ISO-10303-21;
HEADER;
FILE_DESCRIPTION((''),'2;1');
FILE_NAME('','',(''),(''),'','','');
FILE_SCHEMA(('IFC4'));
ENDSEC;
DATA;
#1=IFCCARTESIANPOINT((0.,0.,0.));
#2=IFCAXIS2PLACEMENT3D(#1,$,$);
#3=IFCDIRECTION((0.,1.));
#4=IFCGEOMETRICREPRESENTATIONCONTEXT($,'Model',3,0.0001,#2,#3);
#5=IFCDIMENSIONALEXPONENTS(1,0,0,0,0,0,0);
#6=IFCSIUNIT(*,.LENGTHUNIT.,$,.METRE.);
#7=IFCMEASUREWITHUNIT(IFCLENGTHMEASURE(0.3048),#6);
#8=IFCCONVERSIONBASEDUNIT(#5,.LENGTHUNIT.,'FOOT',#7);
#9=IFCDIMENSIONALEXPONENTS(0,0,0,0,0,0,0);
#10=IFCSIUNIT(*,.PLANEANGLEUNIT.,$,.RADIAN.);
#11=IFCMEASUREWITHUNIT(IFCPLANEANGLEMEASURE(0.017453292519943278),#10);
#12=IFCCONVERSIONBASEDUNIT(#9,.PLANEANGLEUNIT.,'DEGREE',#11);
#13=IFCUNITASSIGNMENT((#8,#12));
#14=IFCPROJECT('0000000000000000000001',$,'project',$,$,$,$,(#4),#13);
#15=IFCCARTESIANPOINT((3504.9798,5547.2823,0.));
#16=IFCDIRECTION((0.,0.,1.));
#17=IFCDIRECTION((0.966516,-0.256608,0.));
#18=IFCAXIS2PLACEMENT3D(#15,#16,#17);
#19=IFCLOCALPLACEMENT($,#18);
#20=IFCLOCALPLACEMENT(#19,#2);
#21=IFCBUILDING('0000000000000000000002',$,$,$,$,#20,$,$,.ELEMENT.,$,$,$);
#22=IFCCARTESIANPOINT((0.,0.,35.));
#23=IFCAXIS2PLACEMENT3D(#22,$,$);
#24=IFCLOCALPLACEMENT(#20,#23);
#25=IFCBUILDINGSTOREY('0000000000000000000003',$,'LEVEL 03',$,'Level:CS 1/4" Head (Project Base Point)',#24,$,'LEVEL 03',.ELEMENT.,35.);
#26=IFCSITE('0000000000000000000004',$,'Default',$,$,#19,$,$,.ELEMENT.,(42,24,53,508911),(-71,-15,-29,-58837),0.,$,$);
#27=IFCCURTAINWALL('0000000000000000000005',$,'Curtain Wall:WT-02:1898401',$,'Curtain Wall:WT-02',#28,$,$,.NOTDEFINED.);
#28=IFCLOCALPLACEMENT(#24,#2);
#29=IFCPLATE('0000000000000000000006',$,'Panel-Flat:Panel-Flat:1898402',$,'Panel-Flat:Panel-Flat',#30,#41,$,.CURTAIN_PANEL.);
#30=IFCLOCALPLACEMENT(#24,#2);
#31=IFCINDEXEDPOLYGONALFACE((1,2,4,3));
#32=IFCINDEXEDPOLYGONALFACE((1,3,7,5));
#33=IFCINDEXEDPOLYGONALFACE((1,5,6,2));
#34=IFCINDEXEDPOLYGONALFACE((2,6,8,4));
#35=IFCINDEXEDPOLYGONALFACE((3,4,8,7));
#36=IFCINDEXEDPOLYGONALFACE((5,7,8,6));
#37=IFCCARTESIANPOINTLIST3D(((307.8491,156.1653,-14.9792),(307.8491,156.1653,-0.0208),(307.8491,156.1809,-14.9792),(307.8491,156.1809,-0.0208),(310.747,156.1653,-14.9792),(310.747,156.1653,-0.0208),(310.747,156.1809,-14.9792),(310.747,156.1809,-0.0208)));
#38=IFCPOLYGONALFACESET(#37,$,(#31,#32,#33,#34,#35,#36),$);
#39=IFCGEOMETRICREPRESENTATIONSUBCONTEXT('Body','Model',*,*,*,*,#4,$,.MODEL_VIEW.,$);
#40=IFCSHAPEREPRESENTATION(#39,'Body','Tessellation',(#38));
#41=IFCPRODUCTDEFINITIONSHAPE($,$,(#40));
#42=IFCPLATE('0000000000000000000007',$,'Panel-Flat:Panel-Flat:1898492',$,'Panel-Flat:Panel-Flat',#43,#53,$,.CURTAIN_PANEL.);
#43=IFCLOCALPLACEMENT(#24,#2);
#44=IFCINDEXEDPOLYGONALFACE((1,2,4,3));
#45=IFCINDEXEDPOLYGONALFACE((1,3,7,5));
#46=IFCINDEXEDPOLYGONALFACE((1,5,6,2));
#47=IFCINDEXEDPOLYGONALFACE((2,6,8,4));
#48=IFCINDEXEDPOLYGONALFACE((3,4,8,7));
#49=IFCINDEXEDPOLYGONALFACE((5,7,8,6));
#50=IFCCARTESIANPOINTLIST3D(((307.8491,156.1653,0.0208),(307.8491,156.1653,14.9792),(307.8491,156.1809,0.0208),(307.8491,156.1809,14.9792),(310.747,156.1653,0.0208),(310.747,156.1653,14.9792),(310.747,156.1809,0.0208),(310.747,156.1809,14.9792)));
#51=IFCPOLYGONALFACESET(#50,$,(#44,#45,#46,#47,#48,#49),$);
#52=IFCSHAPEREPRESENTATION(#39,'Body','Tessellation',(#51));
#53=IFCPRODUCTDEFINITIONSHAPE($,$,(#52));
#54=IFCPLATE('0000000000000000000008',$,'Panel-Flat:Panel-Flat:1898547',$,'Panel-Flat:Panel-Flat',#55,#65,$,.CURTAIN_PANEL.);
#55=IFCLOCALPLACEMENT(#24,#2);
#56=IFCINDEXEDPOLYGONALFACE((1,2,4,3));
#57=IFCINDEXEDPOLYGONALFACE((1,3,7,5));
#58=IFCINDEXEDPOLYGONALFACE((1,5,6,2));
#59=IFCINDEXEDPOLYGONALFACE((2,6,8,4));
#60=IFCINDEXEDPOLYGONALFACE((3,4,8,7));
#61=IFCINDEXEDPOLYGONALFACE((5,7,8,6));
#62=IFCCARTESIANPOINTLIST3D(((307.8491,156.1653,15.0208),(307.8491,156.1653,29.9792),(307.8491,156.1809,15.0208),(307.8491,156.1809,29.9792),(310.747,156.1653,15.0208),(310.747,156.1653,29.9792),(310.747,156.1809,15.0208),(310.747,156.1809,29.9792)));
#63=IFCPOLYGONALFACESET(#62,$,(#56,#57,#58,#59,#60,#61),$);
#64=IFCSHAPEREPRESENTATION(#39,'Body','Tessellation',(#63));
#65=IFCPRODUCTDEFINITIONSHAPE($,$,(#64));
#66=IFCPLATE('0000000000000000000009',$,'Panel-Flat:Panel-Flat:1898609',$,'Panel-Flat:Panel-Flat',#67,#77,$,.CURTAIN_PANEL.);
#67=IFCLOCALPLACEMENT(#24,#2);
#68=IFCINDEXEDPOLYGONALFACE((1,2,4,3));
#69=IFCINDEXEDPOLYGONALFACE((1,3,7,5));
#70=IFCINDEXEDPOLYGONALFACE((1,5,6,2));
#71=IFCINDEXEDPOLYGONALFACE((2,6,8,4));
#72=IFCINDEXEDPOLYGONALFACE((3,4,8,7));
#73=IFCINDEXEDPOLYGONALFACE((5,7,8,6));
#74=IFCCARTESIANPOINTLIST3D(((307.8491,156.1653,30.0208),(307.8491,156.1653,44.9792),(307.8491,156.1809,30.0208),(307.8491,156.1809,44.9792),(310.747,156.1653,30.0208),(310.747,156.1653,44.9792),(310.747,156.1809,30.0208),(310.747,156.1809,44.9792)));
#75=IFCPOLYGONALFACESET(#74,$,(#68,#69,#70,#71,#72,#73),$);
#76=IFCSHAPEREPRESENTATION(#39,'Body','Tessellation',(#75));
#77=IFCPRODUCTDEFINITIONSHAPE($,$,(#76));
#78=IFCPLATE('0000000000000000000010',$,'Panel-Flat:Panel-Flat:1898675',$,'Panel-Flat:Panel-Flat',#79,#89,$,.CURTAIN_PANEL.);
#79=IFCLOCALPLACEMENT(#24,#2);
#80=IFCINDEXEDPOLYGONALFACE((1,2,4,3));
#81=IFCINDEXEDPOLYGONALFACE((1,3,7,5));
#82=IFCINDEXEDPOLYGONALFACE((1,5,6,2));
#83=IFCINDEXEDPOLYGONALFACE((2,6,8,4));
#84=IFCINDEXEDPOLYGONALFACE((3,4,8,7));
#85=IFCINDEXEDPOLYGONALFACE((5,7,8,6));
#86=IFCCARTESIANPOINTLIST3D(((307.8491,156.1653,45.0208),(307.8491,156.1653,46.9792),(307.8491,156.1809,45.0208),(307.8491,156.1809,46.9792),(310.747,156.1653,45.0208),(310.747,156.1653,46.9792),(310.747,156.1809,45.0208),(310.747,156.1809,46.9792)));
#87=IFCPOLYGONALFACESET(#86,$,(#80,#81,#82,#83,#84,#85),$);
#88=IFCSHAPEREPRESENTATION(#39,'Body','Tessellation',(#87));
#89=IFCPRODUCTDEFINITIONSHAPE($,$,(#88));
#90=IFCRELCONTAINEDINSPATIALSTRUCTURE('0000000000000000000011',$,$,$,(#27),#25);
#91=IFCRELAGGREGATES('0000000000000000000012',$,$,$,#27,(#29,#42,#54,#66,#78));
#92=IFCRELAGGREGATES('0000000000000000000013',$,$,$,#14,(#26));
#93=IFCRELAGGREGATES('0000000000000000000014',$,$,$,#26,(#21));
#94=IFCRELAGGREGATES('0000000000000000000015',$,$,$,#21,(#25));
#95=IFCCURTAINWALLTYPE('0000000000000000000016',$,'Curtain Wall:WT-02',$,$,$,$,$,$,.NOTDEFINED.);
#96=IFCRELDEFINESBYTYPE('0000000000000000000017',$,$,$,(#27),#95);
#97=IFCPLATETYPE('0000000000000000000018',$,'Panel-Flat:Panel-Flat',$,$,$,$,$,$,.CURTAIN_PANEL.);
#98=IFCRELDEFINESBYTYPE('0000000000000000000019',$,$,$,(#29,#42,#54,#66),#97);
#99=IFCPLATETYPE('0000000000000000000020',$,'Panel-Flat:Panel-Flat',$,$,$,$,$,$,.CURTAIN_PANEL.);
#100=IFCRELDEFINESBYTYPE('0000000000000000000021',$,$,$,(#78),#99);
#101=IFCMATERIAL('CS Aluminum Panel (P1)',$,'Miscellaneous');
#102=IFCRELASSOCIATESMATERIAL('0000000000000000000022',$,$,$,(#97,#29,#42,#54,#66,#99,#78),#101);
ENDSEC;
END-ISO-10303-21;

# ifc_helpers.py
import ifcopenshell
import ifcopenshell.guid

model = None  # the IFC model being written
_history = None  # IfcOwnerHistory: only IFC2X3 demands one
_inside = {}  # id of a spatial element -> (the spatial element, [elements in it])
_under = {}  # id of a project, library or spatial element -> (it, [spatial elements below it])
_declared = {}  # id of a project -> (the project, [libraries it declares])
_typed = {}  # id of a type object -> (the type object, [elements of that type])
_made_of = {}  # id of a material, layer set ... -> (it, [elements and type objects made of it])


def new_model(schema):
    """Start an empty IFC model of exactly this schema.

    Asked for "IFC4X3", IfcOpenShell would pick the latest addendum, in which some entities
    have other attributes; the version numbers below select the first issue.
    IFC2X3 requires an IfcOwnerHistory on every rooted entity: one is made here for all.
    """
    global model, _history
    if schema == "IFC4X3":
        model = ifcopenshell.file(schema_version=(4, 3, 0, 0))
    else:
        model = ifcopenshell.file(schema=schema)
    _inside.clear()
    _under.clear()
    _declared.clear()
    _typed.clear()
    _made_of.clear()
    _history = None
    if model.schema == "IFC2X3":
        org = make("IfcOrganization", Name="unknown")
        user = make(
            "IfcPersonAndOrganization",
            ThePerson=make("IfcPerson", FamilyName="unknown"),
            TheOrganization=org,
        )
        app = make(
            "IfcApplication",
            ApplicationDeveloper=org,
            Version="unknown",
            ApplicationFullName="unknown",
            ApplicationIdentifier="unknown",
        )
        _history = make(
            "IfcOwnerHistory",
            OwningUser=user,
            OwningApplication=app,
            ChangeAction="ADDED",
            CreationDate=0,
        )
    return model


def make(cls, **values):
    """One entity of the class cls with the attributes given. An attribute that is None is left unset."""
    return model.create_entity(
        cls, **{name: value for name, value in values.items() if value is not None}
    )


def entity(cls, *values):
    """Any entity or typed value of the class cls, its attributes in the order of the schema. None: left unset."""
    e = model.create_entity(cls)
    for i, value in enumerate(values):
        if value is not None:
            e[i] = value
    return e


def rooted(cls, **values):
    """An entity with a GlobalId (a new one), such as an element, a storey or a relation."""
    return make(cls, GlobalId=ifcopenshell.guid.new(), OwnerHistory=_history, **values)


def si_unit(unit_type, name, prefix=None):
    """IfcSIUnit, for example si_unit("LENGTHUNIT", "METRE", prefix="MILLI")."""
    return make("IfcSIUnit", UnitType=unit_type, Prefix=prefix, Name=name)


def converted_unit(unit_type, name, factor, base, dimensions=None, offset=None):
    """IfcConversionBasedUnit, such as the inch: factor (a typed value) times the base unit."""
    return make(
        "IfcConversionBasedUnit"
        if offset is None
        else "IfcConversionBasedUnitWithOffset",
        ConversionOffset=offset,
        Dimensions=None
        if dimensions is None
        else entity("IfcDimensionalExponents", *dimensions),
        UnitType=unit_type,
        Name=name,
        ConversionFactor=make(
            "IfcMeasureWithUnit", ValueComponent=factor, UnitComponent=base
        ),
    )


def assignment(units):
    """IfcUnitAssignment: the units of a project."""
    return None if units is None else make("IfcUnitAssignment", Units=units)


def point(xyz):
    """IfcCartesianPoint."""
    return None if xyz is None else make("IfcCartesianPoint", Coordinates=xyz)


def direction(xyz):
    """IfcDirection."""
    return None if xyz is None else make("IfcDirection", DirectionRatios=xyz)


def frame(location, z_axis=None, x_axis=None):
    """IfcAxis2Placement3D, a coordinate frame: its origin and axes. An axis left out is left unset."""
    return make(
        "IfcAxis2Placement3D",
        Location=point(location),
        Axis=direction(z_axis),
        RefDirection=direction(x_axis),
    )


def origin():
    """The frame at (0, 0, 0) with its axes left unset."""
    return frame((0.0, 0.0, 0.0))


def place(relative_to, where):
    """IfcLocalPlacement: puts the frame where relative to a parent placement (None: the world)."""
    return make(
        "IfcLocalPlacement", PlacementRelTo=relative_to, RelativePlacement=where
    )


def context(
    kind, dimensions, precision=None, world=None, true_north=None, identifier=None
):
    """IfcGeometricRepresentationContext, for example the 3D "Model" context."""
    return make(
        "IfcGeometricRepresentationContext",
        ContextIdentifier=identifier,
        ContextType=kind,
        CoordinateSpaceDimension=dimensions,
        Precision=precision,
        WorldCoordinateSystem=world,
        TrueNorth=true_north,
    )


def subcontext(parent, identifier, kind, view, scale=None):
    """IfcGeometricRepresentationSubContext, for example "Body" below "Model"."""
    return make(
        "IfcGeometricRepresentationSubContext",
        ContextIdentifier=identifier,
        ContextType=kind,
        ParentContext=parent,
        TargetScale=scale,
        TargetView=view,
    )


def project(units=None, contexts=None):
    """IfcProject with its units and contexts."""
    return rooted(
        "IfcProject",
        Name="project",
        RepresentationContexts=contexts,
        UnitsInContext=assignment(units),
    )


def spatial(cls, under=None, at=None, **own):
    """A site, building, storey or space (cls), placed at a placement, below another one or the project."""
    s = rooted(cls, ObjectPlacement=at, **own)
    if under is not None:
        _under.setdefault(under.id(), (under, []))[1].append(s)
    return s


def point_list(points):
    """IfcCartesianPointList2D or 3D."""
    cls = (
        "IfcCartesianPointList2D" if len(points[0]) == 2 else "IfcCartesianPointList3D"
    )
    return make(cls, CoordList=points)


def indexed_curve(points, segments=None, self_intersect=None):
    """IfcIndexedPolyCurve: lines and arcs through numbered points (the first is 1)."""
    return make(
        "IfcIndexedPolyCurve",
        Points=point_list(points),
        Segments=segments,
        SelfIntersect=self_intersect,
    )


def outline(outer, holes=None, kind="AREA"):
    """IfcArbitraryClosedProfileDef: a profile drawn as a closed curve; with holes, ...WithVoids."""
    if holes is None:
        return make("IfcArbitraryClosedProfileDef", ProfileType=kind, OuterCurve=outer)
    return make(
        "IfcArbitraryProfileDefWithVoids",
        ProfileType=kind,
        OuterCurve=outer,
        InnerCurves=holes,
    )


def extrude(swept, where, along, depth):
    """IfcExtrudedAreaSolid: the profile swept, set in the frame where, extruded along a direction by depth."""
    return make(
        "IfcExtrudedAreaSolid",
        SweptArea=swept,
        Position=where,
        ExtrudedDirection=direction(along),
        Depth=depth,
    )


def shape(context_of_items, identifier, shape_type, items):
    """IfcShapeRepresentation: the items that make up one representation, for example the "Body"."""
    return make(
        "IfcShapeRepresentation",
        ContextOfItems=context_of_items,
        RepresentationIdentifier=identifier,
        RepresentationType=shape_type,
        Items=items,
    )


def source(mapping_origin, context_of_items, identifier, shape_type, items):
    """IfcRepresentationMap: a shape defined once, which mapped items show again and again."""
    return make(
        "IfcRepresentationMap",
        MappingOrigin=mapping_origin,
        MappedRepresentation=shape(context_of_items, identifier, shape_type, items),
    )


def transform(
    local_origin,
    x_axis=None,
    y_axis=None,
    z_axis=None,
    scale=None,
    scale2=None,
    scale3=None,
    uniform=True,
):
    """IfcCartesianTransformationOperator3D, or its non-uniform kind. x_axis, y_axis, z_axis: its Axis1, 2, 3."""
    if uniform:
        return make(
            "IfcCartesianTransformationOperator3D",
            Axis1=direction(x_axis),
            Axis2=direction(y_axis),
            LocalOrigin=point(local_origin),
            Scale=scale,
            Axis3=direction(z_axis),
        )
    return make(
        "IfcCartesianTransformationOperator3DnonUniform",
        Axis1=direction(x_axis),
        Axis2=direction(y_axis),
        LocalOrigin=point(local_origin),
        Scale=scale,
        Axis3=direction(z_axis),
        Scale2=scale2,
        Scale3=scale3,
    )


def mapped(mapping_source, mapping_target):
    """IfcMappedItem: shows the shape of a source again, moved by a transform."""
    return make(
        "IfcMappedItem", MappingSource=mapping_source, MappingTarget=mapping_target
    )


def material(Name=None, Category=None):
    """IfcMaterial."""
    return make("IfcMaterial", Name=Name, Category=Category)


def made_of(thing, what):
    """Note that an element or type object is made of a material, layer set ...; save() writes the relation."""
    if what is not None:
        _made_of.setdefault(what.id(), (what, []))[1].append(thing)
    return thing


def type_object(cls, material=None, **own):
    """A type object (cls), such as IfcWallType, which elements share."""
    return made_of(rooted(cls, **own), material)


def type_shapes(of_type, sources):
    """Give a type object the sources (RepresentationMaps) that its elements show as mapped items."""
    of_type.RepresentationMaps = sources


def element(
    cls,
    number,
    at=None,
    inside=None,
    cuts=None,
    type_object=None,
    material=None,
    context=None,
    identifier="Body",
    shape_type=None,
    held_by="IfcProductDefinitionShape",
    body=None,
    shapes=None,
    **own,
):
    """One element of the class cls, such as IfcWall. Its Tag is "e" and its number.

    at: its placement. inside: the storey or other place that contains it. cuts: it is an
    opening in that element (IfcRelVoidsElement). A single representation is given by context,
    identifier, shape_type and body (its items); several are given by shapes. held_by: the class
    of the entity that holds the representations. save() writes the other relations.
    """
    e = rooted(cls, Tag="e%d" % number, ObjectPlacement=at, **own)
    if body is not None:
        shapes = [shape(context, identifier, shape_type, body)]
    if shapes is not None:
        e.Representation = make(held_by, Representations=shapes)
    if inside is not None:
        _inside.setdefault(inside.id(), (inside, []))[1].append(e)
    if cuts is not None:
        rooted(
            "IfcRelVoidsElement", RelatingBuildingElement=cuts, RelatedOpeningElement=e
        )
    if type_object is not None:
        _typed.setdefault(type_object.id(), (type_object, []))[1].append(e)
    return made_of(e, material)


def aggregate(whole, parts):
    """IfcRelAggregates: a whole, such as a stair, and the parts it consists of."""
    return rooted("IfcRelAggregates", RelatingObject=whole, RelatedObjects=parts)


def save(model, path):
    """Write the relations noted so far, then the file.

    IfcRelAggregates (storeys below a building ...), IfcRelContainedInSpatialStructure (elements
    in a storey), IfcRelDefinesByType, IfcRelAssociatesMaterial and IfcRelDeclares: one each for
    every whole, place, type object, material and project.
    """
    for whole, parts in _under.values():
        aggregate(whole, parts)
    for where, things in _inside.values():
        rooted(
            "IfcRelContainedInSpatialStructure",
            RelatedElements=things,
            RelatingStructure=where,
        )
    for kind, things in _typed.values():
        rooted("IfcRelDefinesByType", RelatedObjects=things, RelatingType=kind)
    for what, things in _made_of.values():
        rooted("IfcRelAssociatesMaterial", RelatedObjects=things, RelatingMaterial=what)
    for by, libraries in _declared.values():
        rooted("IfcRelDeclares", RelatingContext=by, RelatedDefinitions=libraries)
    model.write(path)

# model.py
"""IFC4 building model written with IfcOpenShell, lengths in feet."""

from ifc_helpers import new_model, entity, si_unit, converted_unit, direction, frame, origin, place, context, subcontext, project, spatial, indexed_curve, outline, extrude, source, transform, mapped, material, type_object, type_shapes, element, aggregate, save


model = new_model("IFC4")

# Units and contexts
model_context = context("Model", 3, precision=0.0001, world=origin(), true_north=direction((0.0, 1.0)))
body_context = subcontext(model_context, "Body", "Model", "MODEL_VIEW")
ifc_project = project(units=[converted_unit("LENGTHUNIT", "FOOT", entity("IfcLengthMeasure", 0.3048), si_unit("LENGTHUNIT", "METRE"), dimensions=[1, 0, 0, 0, 0, 0, 0]), converted_unit("PLANEANGLEUNIT", "DEGREE", entity("IfcPlaneAngleMeasure", 0.017453292519943278), si_unit("PLANEANGLEUNIT", "RADIAN"), dimensions=[0, 0, 0, 0, 0, 0, 0])], contexts=[model_context])

# Site, building, storey
site_placement = place(None, frame((3504.9798, 5547.2823, 0.0), z_axis=(0.0, 0.0, 1.0), x_axis=(0.966516, -0.256608, 0.0)))
site = spatial("IfcSite", under=ifc_project, at=site_placement, Name="Default", CompositionType="ELEMENT", RefLatitude=(42, 24, 53, 508911), RefLongitude=(-71, -15, -29, -58837), RefElevation=0.0)
building_placement = place(site_placement, origin())
building = spatial("IfcBuilding", under=site, at=building_placement, CompositionType="ELEMENT")
storey_placement = place(building_placement, frame((0.0, 0.0, 35.0)))
storey = spatial("IfcBuildingStorey", under=building, at=storey_placement, Name="LEVEL 03", ObjectType="Level:CS 1/4\" Head (Project Base Point)", LongName="LEVEL 03", CompositionType="ELEMENT", Elevation=35.0)

# Curtain wall, plates
curtain_wall_type = type_object("IfcCurtainWallType", Name="Curtain Wall:WT-02", PredefinedType="NOTDEFINED")
curtain_wall_1_placement = place(storey_placement, frame((0.0, 0.0, -35.0)))
curtain_wall_1 = element("IfcCurtainWall", 1, at=curtain_wall_1_placement, inside=storey, type_object=curtain_wall_type, Name="Curtain Wall:WT-02:1898401", ObjectType="Curtain Wall:WT-02", PredefinedType="NOTDEFINED")
ifc_material_1 = material(Name="CS Aluminum Panel (P1)", Category="Miscellaneous")
plate_type_1 = type_object("IfcPlateType", Name="Panel-Flat:Panel-Flat", PredefinedType="CURTAIN_PANEL", material=ifc_material_1)
shared_shape_1 = source(origin(), body_context, "Body", "SweptSolid", [
    extrude(outline(indexed_curve([(-0.0078, -1.4489), (0.0078, -1.4489), (0.0078, 1.4489), (-0.0078, 1.4489), (-0.0078, -1.4489)], self_intersect=False)), frame((0.0, -0.0078, 0.0208), z_axis=(0.0, 0.0, 1.0), x_axis=(0.0, -1.0, 0.0)), (0.0, 0.0, 1.0), 14.9583),
])
type_shapes(plate_type_1, [shared_shape_1])
plate_1_placement = place(curtain_wall_1_placement, frame((309.2981, 156.1653, 20.0), z_axis=(0.0, 0.0, 1.0), x_axis=(-1.0, 0.0, 0.0)))
plate_1 = element("IfcPlate", 2, at=plate_1_placement, type_object=plate_type_1, material=ifc_material_1, Name="Panel-Flat:Panel-Flat:1898402", ObjectType="Panel-Flat:Panel-Flat", PredefinedType="CURTAIN_PANEL", context=body_context, shape_type="MappedRepresentation", body=[
    mapped(shared_shape_1, transform((0.0, 0.0, 0.0), scale=1.0)),
])
plate_2_placement = place(curtain_wall_1_placement, frame((309.2981, 156.1653, 35.0), z_axis=(0.0, 0.0, 1.0), x_axis=(-1.0, 0.0, 0.0)))
plate_2 = element("IfcPlate", 3, at=plate_2_placement, type_object=plate_type_1, material=ifc_material_1, Name="Panel-Flat:Panel-Flat:1898492", ObjectType="Panel-Flat:Panel-Flat", PredefinedType="CURTAIN_PANEL", context=body_context, shape_type="MappedRepresentation", body=[
    mapped(shared_shape_1, transform((0.0, 0.0, 0.0), scale=1.0)),
])
plate_3_placement = place(curtain_wall_1_placement, frame((309.2981, 156.1653, 50.0), z_axis=(0.0, 0.0, 1.0), x_axis=(-1.0, 0.0, 0.0)))
plate_3 = element("IfcPlate", 4, at=plate_3_placement, type_object=plate_type_1, material=ifc_material_1, Name="Panel-Flat:Panel-Flat:1898547", ObjectType="Panel-Flat:Panel-Flat", PredefinedType="CURTAIN_PANEL", context=body_context, shape_type="MappedRepresentation", body=[
    mapped(shared_shape_1, transform((0.0, 0.0, 0.0), scale=1.0)),
])
plate_4_placement = place(curtain_wall_1_placement, frame((309.2981, 156.1653, 65.0), z_axis=(0.0, 0.0, 1.0), x_axis=(-1.0, 0.0, 0.0)))
plate_4 = element("IfcPlate", 5, at=plate_4_placement, type_object=plate_type_1, material=ifc_material_1, Name="Panel-Flat:Panel-Flat:1898609", ObjectType="Panel-Flat:Panel-Flat", PredefinedType="CURTAIN_PANEL", context=body_context, shape_type="MappedRepresentation", body=[
    mapped(shared_shape_1, transform((0.0, 0.0, 0.0), scale=1.0)),
])
plate_type_2 = type_object("IfcPlateType", Name="Panel-Flat:Panel-Flat", PredefinedType="CURTAIN_PANEL", material=ifc_material_1)
shared_shape_2 = source(origin(), body_context, "Body", "SweptSolid", [
    extrude(outline(indexed_curve([(-0.0078, -1.4489), (0.0078, -1.4489), (0.0078, 1.4489), (-0.0078, 1.4489), (-0.0078, -1.4489)], self_intersect=False)), frame((0.0, -0.0078, 0.0208), z_axis=(0.0, 0.0, 1.0), x_axis=(0.0, -1.0, 0.0)), (0.0, 0.0, 1.0), 1.9583),
])
type_shapes(plate_type_2, [shared_shape_2])
plate_5_placement = place(curtain_wall_1_placement, frame((309.2981, 156.1653, 80.0), z_axis=(0.0, 0.0, 1.0), x_axis=(-1.0, 0.0, 0.0)))
plate_5 = element("IfcPlate", 6, at=plate_5_placement, type_object=plate_type_2, material=ifc_material_1, Name="Panel-Flat:Panel-Flat:1898675", ObjectType="Panel-Flat:Panel-Flat", PredefinedType="CURTAIN_PANEL", context=body_context, shape_type="MappedRepresentation", body=[
    mapped(shared_shape_2, transform((0.0, 0.0, 0.0), scale=1.0)),
])
aggregate(curtain_wall_1, [plate_1, plate_2, plate_3, plate_4, plate_5])

save(model, "model.ifc")
